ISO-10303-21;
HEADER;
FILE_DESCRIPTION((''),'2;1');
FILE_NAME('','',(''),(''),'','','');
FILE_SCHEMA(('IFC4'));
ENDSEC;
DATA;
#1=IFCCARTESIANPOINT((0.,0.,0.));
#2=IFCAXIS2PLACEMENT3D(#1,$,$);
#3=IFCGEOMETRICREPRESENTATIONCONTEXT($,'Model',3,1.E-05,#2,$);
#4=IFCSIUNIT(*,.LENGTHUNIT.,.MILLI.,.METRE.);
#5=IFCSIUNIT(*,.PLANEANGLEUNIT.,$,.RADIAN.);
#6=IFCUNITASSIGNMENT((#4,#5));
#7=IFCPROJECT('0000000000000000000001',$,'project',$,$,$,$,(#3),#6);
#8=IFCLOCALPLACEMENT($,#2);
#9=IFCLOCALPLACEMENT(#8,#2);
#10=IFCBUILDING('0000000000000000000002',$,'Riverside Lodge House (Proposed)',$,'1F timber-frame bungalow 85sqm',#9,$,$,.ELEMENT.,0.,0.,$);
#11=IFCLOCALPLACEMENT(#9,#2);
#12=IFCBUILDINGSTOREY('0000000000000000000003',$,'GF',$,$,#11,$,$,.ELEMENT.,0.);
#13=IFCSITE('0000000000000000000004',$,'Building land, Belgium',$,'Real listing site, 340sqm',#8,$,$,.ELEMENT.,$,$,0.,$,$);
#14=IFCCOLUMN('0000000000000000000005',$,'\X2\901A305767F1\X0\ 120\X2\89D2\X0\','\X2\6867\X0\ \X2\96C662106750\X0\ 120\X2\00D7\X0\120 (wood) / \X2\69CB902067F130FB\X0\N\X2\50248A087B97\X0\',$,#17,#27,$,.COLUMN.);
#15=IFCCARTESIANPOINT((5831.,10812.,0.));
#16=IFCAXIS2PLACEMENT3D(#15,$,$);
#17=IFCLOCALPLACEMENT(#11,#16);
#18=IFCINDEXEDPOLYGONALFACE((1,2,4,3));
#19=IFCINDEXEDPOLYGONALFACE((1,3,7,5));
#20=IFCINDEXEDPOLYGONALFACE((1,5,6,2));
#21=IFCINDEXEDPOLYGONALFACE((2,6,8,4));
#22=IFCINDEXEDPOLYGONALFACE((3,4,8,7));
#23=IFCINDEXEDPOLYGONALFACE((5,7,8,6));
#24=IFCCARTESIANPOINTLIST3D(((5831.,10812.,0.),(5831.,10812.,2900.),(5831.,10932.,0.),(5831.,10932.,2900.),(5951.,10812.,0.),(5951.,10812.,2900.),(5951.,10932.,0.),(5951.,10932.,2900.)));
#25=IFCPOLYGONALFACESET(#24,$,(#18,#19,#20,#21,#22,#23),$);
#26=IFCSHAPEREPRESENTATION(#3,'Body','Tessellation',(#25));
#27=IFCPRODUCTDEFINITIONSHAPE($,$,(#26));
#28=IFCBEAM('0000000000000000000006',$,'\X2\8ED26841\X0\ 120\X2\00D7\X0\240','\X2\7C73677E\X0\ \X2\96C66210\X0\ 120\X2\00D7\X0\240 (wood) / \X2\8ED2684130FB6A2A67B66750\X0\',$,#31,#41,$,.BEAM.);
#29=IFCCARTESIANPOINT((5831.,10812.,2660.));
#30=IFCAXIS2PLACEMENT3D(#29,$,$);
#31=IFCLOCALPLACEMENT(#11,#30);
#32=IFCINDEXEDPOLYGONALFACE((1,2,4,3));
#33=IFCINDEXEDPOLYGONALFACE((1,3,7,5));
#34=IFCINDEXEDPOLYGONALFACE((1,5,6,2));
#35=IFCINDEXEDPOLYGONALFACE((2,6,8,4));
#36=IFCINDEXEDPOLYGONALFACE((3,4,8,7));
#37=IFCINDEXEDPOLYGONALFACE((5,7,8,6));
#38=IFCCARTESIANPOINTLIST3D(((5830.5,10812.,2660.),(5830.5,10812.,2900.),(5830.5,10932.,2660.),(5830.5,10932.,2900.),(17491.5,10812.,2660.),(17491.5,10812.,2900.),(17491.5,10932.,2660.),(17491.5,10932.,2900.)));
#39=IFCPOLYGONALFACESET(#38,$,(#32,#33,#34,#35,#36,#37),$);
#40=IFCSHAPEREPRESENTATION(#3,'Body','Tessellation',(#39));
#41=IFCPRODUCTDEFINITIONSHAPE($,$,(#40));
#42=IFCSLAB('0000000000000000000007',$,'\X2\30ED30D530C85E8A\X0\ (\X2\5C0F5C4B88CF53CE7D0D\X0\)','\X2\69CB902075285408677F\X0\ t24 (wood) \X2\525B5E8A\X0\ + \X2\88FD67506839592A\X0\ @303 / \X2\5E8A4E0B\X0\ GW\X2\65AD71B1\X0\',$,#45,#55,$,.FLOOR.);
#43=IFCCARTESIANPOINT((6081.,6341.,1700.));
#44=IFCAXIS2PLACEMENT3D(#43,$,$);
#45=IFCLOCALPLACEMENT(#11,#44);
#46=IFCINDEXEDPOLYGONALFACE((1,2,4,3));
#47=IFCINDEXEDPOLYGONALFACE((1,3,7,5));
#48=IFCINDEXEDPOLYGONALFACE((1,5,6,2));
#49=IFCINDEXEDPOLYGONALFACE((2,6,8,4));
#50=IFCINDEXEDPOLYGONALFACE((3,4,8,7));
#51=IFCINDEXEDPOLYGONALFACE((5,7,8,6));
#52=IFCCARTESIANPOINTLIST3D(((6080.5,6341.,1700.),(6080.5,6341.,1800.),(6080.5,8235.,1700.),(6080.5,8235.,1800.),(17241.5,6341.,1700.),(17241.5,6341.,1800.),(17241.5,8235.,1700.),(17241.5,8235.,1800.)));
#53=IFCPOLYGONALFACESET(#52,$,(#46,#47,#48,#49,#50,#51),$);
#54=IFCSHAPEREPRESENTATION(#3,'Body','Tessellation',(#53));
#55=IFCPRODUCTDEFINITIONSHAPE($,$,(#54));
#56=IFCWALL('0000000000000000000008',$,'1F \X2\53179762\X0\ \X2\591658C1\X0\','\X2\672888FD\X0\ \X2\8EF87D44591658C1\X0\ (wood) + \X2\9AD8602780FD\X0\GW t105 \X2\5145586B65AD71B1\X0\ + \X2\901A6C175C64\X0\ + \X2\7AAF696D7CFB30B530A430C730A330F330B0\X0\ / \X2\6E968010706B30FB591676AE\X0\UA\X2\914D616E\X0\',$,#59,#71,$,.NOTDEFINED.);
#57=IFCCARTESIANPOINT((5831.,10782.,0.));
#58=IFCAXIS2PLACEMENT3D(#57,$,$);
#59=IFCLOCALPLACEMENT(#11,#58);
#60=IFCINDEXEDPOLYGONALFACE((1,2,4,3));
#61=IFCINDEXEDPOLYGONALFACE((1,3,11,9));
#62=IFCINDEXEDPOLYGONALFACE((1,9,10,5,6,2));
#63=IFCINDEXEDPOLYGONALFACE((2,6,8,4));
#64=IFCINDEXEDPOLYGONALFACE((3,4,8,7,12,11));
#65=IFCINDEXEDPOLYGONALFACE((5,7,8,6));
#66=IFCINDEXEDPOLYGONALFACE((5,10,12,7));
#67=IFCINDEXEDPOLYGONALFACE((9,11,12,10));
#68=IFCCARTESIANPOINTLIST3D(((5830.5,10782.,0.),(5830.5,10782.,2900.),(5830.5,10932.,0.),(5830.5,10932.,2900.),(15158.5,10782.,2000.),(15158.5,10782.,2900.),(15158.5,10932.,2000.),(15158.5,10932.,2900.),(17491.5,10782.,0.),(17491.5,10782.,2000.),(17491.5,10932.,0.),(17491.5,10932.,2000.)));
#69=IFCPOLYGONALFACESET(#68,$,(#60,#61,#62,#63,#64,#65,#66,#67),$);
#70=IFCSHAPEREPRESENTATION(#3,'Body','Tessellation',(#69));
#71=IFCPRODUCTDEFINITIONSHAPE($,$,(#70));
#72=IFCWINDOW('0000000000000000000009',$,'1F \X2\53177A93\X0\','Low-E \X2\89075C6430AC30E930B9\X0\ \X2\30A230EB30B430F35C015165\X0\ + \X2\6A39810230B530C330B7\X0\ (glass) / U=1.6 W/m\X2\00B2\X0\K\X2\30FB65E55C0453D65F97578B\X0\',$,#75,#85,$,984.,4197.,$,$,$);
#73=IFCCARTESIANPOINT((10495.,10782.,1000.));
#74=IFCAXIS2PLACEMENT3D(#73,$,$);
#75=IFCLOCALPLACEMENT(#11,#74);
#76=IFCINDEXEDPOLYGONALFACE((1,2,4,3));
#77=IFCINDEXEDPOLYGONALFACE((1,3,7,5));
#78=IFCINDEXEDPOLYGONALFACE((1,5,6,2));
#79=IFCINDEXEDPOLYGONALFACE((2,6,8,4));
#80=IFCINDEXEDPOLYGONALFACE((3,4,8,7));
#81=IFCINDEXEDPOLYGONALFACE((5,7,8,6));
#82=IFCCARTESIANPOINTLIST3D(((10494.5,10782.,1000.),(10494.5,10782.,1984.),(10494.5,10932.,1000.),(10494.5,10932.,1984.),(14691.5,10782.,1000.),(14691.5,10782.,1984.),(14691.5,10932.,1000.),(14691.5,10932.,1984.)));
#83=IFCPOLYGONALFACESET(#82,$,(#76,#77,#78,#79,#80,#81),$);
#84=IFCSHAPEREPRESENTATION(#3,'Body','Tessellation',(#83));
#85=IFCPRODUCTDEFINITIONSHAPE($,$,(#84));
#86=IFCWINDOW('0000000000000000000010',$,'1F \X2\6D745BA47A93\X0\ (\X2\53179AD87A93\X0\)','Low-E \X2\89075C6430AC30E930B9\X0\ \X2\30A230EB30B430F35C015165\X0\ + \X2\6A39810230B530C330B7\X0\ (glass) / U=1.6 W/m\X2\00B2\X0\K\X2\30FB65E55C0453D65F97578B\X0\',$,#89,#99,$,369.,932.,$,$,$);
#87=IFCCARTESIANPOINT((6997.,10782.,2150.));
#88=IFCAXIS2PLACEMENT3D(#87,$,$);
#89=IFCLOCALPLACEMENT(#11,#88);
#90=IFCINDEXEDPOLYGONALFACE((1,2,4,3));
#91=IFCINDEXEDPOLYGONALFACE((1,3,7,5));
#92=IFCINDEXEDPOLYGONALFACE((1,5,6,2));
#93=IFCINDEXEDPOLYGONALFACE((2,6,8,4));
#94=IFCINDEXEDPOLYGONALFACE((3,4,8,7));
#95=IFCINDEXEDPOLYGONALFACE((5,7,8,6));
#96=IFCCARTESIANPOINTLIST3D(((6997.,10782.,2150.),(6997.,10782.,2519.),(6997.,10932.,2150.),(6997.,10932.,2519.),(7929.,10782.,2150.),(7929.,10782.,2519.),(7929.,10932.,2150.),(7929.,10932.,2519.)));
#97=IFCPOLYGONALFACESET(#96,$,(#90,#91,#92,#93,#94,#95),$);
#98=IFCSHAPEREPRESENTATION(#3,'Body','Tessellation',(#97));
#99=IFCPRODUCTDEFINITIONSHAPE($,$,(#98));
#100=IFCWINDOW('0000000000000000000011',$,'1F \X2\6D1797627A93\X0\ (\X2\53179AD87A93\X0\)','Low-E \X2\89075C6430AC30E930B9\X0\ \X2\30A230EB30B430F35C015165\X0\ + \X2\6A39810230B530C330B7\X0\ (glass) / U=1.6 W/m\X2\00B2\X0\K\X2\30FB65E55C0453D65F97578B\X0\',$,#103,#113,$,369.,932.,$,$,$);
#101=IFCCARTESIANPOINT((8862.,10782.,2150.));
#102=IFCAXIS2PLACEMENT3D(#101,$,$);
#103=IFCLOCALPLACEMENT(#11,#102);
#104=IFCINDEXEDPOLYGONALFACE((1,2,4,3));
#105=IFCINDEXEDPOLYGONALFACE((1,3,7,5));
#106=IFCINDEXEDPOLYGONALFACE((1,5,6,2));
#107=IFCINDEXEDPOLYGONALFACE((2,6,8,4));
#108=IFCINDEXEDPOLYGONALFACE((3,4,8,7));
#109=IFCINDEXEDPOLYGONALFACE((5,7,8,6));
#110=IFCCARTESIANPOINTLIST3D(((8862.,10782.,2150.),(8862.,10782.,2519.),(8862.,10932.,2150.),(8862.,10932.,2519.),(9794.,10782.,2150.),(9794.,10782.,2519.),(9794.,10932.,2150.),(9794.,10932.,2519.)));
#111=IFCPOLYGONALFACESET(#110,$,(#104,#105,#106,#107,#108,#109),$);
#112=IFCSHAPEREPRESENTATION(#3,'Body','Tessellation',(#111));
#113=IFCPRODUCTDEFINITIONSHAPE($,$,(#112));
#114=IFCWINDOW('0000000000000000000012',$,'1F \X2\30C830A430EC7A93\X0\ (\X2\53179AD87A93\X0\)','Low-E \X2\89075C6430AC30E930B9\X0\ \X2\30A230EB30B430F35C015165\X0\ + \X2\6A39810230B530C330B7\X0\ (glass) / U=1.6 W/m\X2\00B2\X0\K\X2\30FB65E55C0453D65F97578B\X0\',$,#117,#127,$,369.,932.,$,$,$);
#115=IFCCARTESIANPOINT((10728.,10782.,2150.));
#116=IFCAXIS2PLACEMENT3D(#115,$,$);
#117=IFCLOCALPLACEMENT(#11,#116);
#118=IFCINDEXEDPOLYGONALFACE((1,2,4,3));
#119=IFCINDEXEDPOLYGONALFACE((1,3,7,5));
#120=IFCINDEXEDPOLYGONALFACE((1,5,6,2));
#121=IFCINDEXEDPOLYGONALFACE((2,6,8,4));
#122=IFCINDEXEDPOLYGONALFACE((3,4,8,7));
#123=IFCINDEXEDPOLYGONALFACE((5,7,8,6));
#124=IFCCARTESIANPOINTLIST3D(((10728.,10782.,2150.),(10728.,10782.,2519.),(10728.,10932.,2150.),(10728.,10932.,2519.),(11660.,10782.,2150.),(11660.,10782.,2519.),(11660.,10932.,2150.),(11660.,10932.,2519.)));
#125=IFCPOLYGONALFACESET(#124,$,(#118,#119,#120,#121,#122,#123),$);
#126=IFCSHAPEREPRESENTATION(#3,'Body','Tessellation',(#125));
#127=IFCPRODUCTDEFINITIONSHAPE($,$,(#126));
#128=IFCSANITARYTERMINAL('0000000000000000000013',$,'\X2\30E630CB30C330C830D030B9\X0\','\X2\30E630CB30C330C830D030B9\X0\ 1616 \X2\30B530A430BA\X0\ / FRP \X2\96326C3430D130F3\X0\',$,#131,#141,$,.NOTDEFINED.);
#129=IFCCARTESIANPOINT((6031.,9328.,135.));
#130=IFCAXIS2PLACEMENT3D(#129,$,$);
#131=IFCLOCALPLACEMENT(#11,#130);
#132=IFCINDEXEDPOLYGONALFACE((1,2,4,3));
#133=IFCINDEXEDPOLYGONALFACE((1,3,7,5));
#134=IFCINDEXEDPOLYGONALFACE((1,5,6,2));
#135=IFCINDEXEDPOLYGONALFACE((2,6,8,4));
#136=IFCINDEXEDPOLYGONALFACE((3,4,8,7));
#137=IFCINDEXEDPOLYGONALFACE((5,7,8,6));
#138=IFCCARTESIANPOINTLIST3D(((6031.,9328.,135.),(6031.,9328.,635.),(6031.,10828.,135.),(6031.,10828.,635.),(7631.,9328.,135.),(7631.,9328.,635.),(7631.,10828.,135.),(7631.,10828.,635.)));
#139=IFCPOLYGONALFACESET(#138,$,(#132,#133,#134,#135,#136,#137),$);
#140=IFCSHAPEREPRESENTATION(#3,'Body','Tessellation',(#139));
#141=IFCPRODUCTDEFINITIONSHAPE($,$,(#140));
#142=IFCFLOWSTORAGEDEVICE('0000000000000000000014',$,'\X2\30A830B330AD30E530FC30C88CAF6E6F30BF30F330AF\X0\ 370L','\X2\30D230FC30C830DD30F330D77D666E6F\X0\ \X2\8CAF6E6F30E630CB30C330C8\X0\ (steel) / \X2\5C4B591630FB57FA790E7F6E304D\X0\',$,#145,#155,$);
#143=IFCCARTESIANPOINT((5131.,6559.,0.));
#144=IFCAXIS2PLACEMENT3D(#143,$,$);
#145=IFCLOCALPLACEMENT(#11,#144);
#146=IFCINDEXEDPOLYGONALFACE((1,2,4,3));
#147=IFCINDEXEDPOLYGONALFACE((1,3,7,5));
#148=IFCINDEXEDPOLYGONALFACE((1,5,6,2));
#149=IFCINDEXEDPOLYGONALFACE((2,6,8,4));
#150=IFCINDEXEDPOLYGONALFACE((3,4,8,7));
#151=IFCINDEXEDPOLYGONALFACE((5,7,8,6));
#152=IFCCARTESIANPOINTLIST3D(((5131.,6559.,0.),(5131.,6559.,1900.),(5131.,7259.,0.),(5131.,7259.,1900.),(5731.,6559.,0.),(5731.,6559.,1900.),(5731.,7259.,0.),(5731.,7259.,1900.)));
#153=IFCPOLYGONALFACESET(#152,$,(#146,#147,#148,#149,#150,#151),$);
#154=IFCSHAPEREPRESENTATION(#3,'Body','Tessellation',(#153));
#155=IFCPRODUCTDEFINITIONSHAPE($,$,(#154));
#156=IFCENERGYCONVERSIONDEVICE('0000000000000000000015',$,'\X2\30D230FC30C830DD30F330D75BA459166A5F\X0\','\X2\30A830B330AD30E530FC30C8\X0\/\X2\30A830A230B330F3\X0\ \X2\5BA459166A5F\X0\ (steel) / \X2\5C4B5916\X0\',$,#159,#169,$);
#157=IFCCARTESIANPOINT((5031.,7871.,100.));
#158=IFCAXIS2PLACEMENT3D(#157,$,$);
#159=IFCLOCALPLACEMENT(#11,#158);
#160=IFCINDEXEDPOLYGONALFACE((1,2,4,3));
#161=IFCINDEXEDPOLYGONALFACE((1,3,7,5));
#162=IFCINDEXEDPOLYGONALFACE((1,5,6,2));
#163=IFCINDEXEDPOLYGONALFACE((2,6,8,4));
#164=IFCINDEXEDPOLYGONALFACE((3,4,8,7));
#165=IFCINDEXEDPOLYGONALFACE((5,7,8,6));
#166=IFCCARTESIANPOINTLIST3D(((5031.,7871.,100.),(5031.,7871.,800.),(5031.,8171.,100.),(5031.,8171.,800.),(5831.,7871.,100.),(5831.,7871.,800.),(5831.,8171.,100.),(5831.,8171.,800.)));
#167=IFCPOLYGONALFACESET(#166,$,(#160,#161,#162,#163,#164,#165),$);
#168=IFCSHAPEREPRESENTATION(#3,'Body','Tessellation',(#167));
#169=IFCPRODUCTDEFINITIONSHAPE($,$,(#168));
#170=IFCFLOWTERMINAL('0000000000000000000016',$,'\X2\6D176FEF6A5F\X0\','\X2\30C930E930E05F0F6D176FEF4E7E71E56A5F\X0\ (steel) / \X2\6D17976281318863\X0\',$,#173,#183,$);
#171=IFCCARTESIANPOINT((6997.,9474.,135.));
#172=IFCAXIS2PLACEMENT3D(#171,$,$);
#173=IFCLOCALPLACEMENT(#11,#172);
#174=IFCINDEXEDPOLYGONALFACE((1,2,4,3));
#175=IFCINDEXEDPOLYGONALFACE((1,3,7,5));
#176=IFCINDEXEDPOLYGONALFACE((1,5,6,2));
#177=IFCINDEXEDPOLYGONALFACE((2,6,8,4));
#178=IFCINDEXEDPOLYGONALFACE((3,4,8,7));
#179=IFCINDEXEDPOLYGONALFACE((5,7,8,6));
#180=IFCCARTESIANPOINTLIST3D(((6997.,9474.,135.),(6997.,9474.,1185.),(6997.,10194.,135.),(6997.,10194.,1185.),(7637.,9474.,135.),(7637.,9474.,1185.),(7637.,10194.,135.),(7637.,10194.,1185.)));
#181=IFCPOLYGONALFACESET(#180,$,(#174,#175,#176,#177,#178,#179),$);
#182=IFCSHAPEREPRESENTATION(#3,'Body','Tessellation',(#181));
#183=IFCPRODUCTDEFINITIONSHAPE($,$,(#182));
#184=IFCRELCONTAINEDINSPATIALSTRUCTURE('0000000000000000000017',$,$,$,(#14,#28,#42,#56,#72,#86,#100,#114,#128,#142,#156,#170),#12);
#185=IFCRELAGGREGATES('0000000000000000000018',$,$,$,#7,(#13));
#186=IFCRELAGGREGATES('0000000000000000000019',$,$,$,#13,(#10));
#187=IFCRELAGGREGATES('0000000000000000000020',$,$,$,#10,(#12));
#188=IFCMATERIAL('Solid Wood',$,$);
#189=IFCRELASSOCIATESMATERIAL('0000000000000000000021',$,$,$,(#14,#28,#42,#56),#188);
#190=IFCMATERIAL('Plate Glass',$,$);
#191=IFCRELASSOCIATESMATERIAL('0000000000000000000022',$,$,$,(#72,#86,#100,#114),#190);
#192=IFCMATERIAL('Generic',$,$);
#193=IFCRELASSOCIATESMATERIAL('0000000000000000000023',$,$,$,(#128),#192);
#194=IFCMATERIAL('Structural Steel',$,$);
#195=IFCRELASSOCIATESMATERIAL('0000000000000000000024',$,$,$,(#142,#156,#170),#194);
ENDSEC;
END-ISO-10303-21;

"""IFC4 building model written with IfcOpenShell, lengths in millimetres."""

from ifc_helpers import new_model, si_unit, frame, frame_2d, origin, place, context, project, spatial, rectangle, extrude, material, element, fill, save


model = new_model("IFC4")

# Units and contexts
model_context = context("Model", 3, precision=1e-05, world=origin())
ifc_project = project(units=[si_unit("LENGTHUNIT", "METRE", prefix="MILLI"), si_unit("PLANEANGLEUNIT", "RADIAN")], contexts=[model_context])

# Site, building, storey
site_placement = place(None, origin())
site = spatial("IfcSite", under=ifc_project, at=site_placement, Name="Building land, Belgium", ObjectType="Real listing site, 340sqm", CompositionType="ELEMENT", RefElevation=0.0)
building_placement = place(site_placement, origin())
building = spatial("IfcBuilding", under=site, at=building_placement, Name="Riverside Lodge House (Proposed)", ObjectType="1F timber-frame bungalow 85sqm", CompositionType="ELEMENT", ElevationOfRefHeight=0.0, ElevationOfTerrain=0.0)
storey_placement = place(building_placement, origin())
storey = spatial("IfcBuildingStorey", under=building, at=storey_placement, Name="GF", CompositionType="ELEMENT", Elevation=0.0)

# Column
ifc_material_1 = material(Name="Solid Wood")
column_1_placement = place(storey_placement, frame((5831.0, 10812.0, 0.0)))
element("IfcColumn", 1, at=column_1_placement, inside=storey, material=ifc_material_1, Name="通し柱 120角", Description="桧 集成材 120×120 (wood) / 構造柱・N値計算", PredefinedType="COLUMN", context=model_context, shape_type="SweptSolid", body=[
    extrude(rectangle(XDim=120.0, YDim=120.0, at=frame_2d((60.0, 60.0))), frame((5831.0, 10812.0, 0.0)), (0.0, 0.0, 1.0), 2900.0),
])

# Beam
beam_1_placement = place(storey_placement, frame((5831.0, 10812.0, 2660.0)))
element("IfcBeam", 2, at=beam_1_placement, inside=storey, material=ifc_material_1, Name="軒桁 120×240", Description="米松 集成 120×240 (wood) / 軒桁・横架材", PredefinedType="BEAM", context=model_context, shape_type="SweptSolid", body=[
    extrude(rectangle(XDim=11661.0, YDim=120.0, at=frame_2d((5830.0, 60.0))), frame((5831.0, 10812.0, 2660.0)), (0.0, 0.0, 1.0), 240.0),
])

# Slab
slab_placement = place(storey_placement, frame((6081.0, 6341.0, 1700.0)))
element("IfcSlab", 3, at=slab_placement, inside=storey, material=ifc_material_1, Name="ロフト床 (小屋裏収納)", Description="構造用合板 t24 (wood) 剛床 + 製材根太 @303 / 床下 GW断熱", PredefinedType="FLOOR", context=model_context, shape_type="SweptSolid", body=[
    extrude(rectangle(XDim=11161.0, YDim=1894.0, at=frame_2d((5580.0, 947.0))), frame((6081.0, 6341.0, 1700.0)), (0.0, 0.0, 1.0), 100.0),
])

# Wall, openings, windows
wall_1_placement = place(storey_placement, frame((5831.0, 10782.0, 0.0)))
wall_1 = element("IfcWall", 4, at=wall_1_placement, inside=storey, material=ifc_material_1, Name="1F 北面 外壁", Description="木製 軸組外壁 (wood) + 高性能GW t105 充填断熱 + 通気層 + 窯業系サイディング / 準耐火・外皮UA配慮", PredefinedType="NOTDEFINED", context=model_context, shape_type="SweptSolid", body=[
    extrude(rectangle(XDim=11661.0, YDim=150.0, at=frame_2d((5830.0, 75.0))), frame((5831.0, 10782.0, 0.0)), (0.0, 0.0, 1.0), 2900.0),
])
opening_1_placement = place(storey_placement, frame((10495.0, 10782.0, 1000.0)))
opening_1 = element("IfcOpeningElement", 5, at=opening_1_placement, cuts=wall_1, PredefinedType="NOTDEFINED", context=model_context, shape_type="SweptSolid", body=[
    extrude(rectangle(XDim=4197.0, YDim=150.0, at=frame_2d((2098.0, 75.0))), frame((10495.0, 10782.0, 1000.0)), (0.0, 0.0, 1.0), 984.0),
])
opening_2_placement = place(storey_placement, frame((6997.0, 10782.0, 2150.0)))
opening_2 = element("IfcOpeningElement", 6, at=opening_2_placement, cuts=wall_1, PredefinedType="NOTDEFINED", context=model_context, shape_type="SweptSolid", body=[
    extrude(rectangle(XDim=932.0, YDim=150.0, at=frame_2d((466.0, 75.0))), frame((6997.0, 10782.0, 2150.0)), (0.0, 0.0, 1.0), 369.0),
])
opening_3_placement = place(storey_placement, frame((8862.0, 10782.0, 2150.0)))
opening_3 = element("IfcOpeningElement", 7, at=opening_3_placement, cuts=wall_1, PredefinedType="NOTDEFINED", context=model_context, shape_type="SweptSolid", body=[
    extrude(rectangle(XDim=932.0, YDim=150.0, at=frame_2d((466.0, 75.0))), frame((8862.0, 10782.0, 2150.0)), (0.0, 0.0, 1.0), 369.0),
])
opening_4_placement = place(storey_placement, frame((10728.0, 10782.0, 2150.0)))
opening_4 = element("IfcOpeningElement", 8, at=opening_4_placement, cuts=wall_1, PredefinedType="NOTDEFINED", context=model_context, shape_type="SweptSolid", body=[
    extrude(rectangle(XDim=932.0, YDim=150.0, at=frame_2d((466.0, 75.0))), frame((10728.0, 10782.0, 2150.0)), (0.0, 0.0, 1.0), 369.0),
])
ifc_material_2 = material(Name="Plate Glass")
window_1_placement = place(storey_placement, frame((10495.0, 10782.0, 1000.0)))
window_1 = element("IfcWindow", 9, at=window_1_placement, inside=storey, material=ifc_material_2, Name="1F 北窓", Description="Low-E 複層ガラス アルゴン封入 + 樹脂サッシ (glass) / U=1.6 W/m²K・日射取得型", OverallHeight=984.0, OverallWidth=4197.0, context=model_context, shape_type="SweptSolid", body=[
    extrude(rectangle(XDim=4197.0, YDim=150.0, at=frame_2d((2098.0, 75.0))), frame((10495.0, 10782.0, 1000.0)), (0.0, 0.0, 1.0), 984.0),
])
fill(opening_1, window_1)
window_2_placement = place(storey_placement, frame((6997.0, 10782.0, 2150.0)))
window_2 = element("IfcWindow", 10, at=window_2_placement, inside=storey, material=ifc_material_2, Name="1F 浴室窓 (北高窓)", Description="Low-E 複層ガラス アルゴン封入 + 樹脂サッシ (glass) / U=1.6 W/m²K・日射取得型", OverallHeight=369.0, OverallWidth=932.0, context=model_context, shape_type="SweptSolid", body=[
    extrude(rectangle(XDim=932.0, YDim=150.0, at=frame_2d((466.0, 75.0))), frame((6997.0, 10782.0, 2150.0)), (0.0, 0.0, 1.0), 369.0),
])
fill(opening_2, window_2)
window_3_placement = place(storey_placement, frame((8862.0, 10782.0, 2150.0)))
window_3 = element("IfcWindow", 11, at=window_3_placement, inside=storey, material=ifc_material_2, Name="1F 洗面窓 (北高窓)", Description="Low-E 複層ガラス アルゴン封入 + 樹脂サッシ (glass) / U=1.6 W/m²K・日射取得型", OverallHeight=369.0, OverallWidth=932.0, context=model_context, shape_type="SweptSolid", body=[
    extrude(rectangle(XDim=932.0, YDim=150.0, at=frame_2d((466.0, 75.0))), frame((8862.0, 10782.0, 2150.0)), (0.0, 0.0, 1.0), 369.0),
])
fill(opening_3, window_3)
window_4_placement = place(storey_placement, frame((10728.0, 10782.0, 2150.0)))
window_4 = element("IfcWindow", 12, at=window_4_placement, inside=storey, material=ifc_material_2, Name="1F トイレ窓 (北高窓)", Description="Low-E 複層ガラス アルゴン封入 + 樹脂サッシ (glass) / U=1.6 W/m²K・日射取得型", OverallHeight=369.0, OverallWidth=932.0, context=model_context, shape_type="SweptSolid", body=[
    extrude(rectangle(XDim=932.0, YDim=150.0, at=frame_2d((466.0, 75.0))), frame((10728.0, 10782.0, 2150.0)), (0.0, 0.0, 1.0), 369.0),
])
fill(opening_4, window_4)

# Sanitary terminal
ifc_material_3 = material(Name="Generic")
sanitary_terminal_placement = place(storey_placement, frame((6031.0, 9328.0, 135.0)))
element("IfcSanitaryTerminal", 13, at=sanitary_terminal_placement, inside=storey, material=ifc_material_3, Name="ユニットバス", Description="ユニットバス 1616 サイズ / FRP 防水パン", PredefinedType="NOTDEFINED", context=model_context, shape_type="SweptSolid", body=[
    extrude(rectangle(XDim=1600.0, YDim=1500.0, at=frame_2d((800.0, 750.0))), frame((6031.0, 9328.0, 135.0)), (0.0, 0.0, 1.0), 500.0),
])

# Flow storage device
ifc_material_4 = material(Name="Structural Steel")
flow_storage_device_placement = place(storey_placement, frame((5131.0, 6559.0, 0.0)))
element("IfcFlowStorageDevice", 14, at=flow_storage_device_placement, inside=storey, material=ifc_material_4, Name="エコキュート貯湯タンク 370L", Description="ヒートポンプ給湯 貯湯ユニット (steel) / 屋外・基礎置き", context=model_context, shape_type="SweptSolid", body=[
    extrude(rectangle(XDim=600.0, YDim=700.0, at=frame_2d((300.0, 350.0))), frame((5131.0, 6559.0, 0.0)), (0.0, 0.0, 1.0), 1900.0),
])

# Energy conversion device
energy_conversion_device_placement = place(storey_placement, frame((5031.0, 7871.0, 100.0)))
element("IfcEnergyConversionDevice", 15, at=energy_conversion_device_placement, inside=storey, material=ifc_material_4, Name="ヒートポンプ室外機", Description="エコキュート/エアコン 室外機 (steel) / 屋外", context=model_context, shape_type="SweptSolid", body=[
    extrude(rectangle(XDim=800.0, YDim=300.0, at=frame_2d((400.0, 150.0))), frame((5031.0, 7871.0, 100.0)), (0.0, 0.0, 1.0), 700.0),
])

# Flow terminal
flow_terminal_placement = place(storey_placement, frame((6997.0, 9474.0, 135.0)))
element("IfcFlowTerminal", 16, at=flow_terminal_placement, inside=storey, material=ifc_material_4, Name="洗濯機", Description="ドラム式洗濯乾燥機 (steel) / 洗面脱衣", context=model_context, shape_type="SweptSolid", body=[
    extrude(rectangle(XDim=640.0, YDim=720.0, at=frame_2d((320.0, 360.0))), frame((6997.0, 9474.0, 135.0)), (0.0, 0.0, 1.0), 1050.0),
])

save(model, "model.ifc")
